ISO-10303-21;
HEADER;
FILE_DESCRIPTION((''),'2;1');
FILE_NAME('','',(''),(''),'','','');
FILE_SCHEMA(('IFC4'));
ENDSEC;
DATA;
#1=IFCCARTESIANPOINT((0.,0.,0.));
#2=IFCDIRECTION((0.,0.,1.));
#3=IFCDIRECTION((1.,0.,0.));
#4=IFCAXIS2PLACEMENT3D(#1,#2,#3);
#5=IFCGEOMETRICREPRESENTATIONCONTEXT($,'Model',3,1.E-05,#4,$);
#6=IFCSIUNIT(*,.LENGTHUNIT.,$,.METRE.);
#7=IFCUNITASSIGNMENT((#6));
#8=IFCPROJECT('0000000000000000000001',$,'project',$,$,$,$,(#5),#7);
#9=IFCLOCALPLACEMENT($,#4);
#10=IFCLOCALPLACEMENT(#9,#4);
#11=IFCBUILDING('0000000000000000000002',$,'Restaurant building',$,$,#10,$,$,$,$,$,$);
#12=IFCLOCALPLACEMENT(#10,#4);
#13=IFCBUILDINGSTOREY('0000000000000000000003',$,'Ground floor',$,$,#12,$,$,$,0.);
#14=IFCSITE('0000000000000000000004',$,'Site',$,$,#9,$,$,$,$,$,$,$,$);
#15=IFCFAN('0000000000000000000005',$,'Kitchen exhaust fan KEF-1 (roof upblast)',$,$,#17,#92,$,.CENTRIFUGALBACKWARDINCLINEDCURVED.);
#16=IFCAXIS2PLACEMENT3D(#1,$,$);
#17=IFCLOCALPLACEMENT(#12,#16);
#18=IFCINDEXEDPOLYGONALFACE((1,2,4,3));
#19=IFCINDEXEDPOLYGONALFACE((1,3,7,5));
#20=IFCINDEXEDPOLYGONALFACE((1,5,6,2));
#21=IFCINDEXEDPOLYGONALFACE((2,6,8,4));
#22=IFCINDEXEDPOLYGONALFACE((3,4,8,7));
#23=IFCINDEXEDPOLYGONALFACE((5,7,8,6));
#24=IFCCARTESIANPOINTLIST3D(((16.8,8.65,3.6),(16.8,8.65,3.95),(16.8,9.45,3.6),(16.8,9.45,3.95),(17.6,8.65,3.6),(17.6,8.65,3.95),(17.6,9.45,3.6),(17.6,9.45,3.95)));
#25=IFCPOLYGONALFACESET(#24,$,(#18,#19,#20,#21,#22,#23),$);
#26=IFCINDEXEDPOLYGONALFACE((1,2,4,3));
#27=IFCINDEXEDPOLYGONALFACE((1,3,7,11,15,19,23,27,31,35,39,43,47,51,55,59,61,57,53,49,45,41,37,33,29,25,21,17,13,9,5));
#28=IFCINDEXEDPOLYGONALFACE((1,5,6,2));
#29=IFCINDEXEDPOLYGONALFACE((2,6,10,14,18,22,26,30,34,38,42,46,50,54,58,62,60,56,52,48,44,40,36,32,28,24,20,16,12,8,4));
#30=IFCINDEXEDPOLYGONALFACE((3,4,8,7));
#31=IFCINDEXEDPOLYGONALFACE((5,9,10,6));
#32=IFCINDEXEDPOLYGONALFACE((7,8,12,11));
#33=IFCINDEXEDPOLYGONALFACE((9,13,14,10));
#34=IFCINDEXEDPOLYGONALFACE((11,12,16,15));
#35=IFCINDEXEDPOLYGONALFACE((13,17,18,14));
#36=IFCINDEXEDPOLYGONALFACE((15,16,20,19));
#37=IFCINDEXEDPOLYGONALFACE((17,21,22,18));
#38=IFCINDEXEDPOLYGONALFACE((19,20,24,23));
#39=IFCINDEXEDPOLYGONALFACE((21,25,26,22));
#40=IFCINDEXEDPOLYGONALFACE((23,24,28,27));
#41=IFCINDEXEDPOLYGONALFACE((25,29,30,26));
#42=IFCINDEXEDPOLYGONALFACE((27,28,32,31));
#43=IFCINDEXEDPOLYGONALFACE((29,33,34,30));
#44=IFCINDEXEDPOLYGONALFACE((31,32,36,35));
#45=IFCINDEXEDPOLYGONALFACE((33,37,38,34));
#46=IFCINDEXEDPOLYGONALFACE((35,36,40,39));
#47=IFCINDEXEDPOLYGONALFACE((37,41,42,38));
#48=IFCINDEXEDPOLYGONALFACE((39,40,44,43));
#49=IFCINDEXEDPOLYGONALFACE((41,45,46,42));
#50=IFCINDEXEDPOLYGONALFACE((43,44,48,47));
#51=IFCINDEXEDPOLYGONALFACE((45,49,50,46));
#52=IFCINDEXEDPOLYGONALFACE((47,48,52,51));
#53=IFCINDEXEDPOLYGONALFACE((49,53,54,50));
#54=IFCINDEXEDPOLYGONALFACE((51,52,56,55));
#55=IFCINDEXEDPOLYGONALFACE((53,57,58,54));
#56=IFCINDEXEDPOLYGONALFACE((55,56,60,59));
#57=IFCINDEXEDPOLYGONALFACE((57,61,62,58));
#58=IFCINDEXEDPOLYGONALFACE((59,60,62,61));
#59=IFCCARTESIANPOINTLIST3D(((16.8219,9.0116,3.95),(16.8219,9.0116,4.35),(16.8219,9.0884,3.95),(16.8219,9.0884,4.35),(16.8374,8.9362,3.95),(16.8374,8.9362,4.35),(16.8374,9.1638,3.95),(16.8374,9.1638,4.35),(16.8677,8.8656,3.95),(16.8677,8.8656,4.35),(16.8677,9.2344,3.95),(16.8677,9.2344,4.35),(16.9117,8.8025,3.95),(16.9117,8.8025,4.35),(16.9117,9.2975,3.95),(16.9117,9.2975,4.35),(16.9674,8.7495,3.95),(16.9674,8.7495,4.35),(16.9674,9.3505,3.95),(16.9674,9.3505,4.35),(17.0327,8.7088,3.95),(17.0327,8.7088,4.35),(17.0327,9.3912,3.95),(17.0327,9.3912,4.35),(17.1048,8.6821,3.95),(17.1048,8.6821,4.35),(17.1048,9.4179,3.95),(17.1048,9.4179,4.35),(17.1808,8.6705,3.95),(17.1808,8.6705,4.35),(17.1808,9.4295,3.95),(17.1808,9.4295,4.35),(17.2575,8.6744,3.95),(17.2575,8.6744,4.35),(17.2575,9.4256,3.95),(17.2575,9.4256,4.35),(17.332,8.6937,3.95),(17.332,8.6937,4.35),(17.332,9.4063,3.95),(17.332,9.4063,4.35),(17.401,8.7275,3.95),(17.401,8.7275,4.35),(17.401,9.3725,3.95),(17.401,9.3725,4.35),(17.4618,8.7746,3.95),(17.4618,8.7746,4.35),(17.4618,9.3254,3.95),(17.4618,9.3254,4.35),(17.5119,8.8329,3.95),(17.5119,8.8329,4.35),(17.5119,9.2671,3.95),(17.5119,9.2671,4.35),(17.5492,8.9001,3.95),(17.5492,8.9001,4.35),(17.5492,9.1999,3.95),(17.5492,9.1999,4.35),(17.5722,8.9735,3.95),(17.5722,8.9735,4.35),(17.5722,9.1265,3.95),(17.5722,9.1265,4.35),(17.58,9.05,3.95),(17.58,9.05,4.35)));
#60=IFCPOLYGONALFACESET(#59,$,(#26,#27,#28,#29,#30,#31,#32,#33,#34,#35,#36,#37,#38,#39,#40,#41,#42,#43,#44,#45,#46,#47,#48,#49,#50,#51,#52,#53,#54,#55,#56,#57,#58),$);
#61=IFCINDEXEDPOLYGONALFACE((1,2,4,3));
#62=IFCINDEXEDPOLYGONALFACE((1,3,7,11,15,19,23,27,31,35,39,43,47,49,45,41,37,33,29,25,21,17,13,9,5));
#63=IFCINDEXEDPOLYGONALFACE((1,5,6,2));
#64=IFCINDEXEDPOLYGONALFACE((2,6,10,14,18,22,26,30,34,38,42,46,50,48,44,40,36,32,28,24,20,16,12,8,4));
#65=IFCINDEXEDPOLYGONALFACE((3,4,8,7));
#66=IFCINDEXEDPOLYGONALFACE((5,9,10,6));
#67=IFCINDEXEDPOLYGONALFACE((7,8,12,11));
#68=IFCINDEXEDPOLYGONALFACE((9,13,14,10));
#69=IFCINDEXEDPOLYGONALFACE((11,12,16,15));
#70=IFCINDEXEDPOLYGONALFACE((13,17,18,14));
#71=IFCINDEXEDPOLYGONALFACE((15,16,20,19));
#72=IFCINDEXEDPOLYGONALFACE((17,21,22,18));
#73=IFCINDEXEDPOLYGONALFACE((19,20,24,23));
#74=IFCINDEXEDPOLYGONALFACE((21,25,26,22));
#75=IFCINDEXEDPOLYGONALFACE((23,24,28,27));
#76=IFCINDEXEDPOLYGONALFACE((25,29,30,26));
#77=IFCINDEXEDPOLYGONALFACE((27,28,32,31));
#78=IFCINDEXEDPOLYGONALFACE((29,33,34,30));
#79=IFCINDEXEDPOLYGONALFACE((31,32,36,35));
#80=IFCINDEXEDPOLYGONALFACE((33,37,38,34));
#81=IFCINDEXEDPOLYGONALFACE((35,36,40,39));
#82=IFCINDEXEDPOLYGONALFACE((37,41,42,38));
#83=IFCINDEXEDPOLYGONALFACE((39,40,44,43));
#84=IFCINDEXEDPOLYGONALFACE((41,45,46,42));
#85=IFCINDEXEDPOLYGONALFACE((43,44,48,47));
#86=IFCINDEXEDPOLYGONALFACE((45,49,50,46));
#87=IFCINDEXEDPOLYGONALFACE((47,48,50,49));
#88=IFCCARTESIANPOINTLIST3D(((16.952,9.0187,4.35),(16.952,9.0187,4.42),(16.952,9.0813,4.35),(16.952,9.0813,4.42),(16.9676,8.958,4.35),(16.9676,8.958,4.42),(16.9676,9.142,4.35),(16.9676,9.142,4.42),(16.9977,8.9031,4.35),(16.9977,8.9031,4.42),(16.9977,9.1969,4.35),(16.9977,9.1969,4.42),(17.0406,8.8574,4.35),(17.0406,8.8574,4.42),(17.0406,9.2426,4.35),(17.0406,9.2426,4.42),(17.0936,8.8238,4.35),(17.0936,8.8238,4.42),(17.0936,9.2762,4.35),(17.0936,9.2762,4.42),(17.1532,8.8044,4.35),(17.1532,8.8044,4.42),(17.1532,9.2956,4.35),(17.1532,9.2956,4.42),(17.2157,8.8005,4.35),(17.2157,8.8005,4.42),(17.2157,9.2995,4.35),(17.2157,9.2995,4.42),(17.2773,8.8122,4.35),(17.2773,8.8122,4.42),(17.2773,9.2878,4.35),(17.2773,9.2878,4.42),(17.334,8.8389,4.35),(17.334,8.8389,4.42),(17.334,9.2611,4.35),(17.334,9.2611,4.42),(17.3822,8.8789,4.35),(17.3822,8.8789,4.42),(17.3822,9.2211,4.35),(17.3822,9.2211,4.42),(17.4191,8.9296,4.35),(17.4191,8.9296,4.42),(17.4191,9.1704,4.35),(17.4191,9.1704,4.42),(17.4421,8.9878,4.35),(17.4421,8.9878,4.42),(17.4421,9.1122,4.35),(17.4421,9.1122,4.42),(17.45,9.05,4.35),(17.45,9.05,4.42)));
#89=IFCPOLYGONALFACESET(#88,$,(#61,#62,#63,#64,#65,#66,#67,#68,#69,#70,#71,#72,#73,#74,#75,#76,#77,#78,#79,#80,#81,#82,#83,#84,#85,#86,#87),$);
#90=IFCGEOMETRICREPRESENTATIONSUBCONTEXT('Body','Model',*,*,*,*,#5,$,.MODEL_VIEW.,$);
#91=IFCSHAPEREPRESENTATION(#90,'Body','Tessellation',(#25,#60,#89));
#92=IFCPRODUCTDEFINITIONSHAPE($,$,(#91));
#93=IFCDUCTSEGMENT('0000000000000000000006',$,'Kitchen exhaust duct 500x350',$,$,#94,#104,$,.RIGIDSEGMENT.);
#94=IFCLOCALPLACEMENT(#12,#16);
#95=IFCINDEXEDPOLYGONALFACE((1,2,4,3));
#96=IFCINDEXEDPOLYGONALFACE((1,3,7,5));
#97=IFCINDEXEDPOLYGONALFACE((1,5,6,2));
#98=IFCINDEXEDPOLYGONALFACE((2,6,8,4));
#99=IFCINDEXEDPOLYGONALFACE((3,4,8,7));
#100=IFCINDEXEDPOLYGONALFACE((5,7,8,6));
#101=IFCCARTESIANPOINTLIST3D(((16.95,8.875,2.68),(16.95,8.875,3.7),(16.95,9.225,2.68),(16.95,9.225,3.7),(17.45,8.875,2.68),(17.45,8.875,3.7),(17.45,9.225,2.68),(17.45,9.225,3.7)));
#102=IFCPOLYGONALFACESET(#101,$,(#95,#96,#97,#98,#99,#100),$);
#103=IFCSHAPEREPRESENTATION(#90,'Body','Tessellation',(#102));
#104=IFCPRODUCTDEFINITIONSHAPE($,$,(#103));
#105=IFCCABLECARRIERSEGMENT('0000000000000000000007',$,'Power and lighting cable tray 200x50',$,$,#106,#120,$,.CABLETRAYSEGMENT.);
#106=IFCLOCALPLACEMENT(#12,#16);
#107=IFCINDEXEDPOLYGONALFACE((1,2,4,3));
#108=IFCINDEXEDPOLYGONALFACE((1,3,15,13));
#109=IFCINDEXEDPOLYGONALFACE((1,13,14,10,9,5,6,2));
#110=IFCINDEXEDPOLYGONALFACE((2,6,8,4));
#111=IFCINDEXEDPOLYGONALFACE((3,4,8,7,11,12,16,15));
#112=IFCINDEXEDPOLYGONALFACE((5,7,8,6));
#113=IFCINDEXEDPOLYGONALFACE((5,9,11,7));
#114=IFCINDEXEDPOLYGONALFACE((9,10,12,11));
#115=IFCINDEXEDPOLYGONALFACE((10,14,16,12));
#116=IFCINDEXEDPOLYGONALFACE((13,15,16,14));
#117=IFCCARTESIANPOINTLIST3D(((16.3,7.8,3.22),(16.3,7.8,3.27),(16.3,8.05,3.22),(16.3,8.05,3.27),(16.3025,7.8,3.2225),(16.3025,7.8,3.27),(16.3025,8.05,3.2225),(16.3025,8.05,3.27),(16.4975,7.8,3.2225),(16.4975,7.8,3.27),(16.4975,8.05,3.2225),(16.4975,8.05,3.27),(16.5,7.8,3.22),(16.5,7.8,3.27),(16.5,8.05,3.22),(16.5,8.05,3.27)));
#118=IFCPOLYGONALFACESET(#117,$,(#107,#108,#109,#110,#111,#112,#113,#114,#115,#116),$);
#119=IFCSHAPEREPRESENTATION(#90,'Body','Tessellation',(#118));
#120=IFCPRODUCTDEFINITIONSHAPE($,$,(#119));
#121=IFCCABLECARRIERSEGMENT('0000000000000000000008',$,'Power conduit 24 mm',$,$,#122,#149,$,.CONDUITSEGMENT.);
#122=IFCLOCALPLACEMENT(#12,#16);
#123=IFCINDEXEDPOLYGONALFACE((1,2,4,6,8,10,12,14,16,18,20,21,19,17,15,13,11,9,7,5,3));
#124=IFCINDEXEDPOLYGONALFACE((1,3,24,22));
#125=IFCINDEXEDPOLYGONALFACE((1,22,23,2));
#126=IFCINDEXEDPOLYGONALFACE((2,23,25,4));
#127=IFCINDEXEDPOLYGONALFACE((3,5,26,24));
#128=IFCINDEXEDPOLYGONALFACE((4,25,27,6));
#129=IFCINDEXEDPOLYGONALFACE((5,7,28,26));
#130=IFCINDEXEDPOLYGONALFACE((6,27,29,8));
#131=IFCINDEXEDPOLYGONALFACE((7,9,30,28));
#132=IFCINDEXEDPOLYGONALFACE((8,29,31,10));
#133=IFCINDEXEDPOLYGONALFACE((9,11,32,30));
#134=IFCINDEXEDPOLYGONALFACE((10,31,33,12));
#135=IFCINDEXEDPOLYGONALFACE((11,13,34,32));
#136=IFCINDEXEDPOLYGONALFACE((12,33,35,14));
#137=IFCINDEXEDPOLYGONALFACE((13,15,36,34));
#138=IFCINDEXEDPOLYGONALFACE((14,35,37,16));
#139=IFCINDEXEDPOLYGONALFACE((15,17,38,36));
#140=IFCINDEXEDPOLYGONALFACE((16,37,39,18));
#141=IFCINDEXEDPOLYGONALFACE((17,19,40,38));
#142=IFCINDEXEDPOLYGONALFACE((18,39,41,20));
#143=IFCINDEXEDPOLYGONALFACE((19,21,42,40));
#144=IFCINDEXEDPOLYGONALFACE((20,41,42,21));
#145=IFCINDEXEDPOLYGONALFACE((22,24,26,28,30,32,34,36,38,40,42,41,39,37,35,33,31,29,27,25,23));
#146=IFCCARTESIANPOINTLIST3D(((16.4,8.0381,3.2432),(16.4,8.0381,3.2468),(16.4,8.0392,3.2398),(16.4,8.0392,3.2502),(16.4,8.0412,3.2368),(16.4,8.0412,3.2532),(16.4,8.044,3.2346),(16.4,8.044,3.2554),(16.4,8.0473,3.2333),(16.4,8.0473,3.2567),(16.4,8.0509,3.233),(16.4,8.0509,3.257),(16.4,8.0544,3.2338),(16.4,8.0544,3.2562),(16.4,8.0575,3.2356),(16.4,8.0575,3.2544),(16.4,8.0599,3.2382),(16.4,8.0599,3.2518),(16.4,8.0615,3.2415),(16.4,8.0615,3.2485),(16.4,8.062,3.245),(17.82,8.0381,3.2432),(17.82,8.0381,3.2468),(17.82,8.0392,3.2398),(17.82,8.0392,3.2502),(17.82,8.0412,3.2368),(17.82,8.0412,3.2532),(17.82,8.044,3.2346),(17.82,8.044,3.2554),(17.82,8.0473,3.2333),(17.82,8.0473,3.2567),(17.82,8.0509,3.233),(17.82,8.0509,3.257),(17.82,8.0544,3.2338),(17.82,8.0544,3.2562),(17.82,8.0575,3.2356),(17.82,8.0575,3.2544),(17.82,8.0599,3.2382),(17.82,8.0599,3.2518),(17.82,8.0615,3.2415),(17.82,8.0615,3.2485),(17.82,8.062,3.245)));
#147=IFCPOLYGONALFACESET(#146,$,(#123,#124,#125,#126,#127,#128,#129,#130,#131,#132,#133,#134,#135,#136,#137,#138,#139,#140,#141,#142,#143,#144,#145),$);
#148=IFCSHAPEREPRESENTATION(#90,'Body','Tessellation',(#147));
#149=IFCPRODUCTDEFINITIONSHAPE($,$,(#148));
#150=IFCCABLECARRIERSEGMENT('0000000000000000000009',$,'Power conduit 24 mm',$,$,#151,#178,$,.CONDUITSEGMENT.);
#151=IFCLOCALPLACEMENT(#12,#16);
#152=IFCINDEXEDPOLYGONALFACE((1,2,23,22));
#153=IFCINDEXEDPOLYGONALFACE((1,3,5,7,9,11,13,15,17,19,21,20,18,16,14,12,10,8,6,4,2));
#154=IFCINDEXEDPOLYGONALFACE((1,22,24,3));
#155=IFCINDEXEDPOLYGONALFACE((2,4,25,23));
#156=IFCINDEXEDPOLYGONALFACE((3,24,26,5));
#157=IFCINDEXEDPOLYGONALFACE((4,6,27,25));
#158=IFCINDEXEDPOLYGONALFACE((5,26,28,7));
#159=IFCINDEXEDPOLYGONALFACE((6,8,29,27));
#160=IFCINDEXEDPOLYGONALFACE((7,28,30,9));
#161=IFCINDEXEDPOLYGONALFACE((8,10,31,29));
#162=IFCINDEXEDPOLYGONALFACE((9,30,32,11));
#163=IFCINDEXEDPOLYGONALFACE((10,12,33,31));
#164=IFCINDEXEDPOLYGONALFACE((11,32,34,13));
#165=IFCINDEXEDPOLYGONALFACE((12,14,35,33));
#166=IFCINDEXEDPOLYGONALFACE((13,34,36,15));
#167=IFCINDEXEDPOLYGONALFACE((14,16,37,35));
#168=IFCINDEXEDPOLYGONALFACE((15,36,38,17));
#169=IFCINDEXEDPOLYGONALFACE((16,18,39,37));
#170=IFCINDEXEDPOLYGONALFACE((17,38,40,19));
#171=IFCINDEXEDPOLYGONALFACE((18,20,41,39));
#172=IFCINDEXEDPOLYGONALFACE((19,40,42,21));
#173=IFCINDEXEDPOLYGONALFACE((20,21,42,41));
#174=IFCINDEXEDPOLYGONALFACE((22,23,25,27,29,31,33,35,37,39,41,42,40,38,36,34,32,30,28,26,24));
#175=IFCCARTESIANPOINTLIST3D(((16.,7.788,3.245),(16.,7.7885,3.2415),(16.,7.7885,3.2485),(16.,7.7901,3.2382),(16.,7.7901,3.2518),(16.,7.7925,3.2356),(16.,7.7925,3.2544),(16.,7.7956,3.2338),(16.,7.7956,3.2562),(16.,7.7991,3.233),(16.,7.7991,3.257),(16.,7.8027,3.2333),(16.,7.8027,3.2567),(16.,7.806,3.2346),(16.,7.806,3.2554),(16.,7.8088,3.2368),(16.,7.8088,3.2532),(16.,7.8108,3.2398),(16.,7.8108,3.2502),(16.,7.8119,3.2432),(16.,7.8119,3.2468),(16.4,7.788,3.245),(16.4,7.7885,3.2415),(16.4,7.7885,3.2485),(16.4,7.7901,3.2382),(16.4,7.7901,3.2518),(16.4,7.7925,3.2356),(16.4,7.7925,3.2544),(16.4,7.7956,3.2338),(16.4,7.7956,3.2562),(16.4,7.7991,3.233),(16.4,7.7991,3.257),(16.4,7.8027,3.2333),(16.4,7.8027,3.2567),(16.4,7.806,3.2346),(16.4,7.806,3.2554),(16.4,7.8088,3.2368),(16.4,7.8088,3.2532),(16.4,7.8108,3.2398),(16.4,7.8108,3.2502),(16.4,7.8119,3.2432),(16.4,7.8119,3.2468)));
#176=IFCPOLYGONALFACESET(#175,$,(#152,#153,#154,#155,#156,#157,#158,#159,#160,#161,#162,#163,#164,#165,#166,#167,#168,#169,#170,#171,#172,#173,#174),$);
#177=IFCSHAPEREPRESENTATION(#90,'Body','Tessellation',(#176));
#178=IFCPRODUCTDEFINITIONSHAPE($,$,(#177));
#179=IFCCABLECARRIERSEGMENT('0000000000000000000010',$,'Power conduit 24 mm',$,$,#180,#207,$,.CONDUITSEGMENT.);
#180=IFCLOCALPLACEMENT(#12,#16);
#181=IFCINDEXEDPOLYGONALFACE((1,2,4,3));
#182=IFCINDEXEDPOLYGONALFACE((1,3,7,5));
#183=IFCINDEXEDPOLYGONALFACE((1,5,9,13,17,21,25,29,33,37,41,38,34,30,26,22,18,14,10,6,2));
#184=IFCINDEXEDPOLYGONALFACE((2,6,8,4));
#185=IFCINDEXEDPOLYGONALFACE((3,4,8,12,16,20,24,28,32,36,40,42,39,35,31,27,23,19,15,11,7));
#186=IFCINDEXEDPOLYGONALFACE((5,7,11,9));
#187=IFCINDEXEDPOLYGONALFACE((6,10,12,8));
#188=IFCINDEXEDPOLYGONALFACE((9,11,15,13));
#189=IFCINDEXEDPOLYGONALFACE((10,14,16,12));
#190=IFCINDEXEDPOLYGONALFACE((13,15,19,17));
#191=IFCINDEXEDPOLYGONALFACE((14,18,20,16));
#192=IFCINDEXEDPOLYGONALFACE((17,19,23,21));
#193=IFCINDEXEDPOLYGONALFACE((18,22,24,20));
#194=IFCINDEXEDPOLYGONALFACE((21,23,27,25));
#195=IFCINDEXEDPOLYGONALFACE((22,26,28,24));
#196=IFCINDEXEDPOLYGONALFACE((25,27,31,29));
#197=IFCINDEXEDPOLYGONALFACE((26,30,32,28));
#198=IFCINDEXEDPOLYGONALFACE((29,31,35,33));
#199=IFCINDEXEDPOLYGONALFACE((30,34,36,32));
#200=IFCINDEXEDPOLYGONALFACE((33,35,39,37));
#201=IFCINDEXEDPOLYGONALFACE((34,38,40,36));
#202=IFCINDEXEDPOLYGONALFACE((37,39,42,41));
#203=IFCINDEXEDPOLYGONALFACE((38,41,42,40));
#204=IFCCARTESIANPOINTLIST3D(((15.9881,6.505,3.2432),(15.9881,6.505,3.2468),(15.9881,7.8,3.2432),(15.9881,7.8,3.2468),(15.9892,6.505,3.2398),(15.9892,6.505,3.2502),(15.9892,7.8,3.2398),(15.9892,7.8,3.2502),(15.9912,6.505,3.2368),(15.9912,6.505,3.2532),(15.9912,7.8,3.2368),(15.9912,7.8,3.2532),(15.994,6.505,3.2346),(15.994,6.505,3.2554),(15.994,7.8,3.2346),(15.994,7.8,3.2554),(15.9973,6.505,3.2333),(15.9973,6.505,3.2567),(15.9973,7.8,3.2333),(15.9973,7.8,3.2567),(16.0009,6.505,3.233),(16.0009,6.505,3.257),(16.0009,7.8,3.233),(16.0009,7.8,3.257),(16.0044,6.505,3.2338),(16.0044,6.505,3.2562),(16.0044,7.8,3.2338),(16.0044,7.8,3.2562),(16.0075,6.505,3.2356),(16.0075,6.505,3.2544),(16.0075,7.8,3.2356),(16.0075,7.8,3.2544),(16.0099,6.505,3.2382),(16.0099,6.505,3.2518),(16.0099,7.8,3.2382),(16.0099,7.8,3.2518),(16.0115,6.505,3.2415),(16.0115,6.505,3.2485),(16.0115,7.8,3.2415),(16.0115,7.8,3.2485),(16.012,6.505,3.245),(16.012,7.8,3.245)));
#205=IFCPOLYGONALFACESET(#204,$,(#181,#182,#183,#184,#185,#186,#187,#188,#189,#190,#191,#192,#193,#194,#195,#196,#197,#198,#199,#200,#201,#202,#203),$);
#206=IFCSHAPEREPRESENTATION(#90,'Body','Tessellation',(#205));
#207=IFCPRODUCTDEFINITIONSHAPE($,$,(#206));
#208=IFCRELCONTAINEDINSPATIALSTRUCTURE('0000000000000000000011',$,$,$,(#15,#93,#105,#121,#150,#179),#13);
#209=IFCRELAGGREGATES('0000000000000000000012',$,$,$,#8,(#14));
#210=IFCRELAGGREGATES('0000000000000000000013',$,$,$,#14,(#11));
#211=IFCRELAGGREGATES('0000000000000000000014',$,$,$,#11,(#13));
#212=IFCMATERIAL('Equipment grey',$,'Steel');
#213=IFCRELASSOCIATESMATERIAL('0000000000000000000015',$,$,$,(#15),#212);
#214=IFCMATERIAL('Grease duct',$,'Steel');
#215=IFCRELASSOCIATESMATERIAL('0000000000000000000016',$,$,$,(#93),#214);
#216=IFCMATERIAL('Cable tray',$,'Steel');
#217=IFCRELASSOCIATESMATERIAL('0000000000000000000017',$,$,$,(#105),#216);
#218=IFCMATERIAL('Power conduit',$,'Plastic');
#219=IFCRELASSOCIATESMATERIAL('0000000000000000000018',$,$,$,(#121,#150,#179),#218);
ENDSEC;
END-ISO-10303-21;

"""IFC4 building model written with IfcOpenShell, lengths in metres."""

from ifc_helpers import new_model, si_unit, frame, origin, origin_with_axes, origin_2d, place, context, subcontext, project, spatial, polyline, rectangle, circle, outline, extrude, material, element, save


model = new_model("IFC4")

# Units and contexts
model_context = context("Model", 3, precision=1e-05, world=origin_with_axes())
body_context = subcontext(model_context, "Body", "Model", "MODEL_VIEW")
ifc_project = project(units=[si_unit("LENGTHUNIT", "METRE")], contexts=[model_context])

# Site, building, storey
site_placement = place(None, origin_with_axes())
site = spatial("IfcSite", under=ifc_project, at=site_placement, Name="Site")
building_placement = place(site_placement, origin_with_axes())
building = spatial("IfcBuilding", under=site, at=building_placement, Name="Restaurant building")
storey_placement = place(building_placement, origin_with_axes())
storey = spatial("IfcBuildingStorey", under=building, at=storey_placement, Name="Ground floor", Elevation=0.0)

# Fan
ifc_material_1 = material(Name="Equipment grey", Category="Steel")
fan_placement = place(storey_placement, frame((17.2, 9.05, 0.0)))
element("IfcFan", 1, at=fan_placement, inside=storey, material=ifc_material_1, Name="Kitchen exhaust fan KEF-1 (roof upblast)", PredefinedType="CENTRIFUGALBACKWARDINCLINEDCURVED", context=body_context, shape_type="SweptSolid", body=[
    extrude(rectangle(XDim=0.8, YDim=0.8, at=origin_2d()), frame((0.0, 0.0, 3.6)), (0.0, 0.0, 1.0), 0.35),
    extrude(circle(Radius=0.38, at=origin_2d()), frame((0.0, 0.0, 3.95)), (0.0, 0.0, 1.0), 0.4),
    extrude(circle(Radius=0.25, at=origin_2d()), frame((0.0, 0.0, 4.35)), (0.0, 0.0, 1.0), 0.07),
])

# Duct segment
ifc_material_2 = material(Name="Grease duct", Category="Steel")
duct_segment_placement = place(storey_placement, frame((17.2, 9.05, 2.68)))
element("IfcDuctSegment", 2, at=duct_segment_placement, inside=storey, material=ifc_material_2, Name="Kitchen exhaust duct 500x350", PredefinedType="RIGIDSEGMENT", context=body_context, shape_type="SweptSolid", body=[
    extrude(rectangle(XDim=0.5, YDim=0.35, at=origin_2d()), origin(), (0.0, 0.0, 1.0), 1.02),
])

# Cable carrier segments
ifc_material_3 = material(Name="Cable tray", Category="Steel")
cable_carrier_segment_1_placement = place(storey_placement, frame((16.4, 8.05, 3.245)))
element("IfcCableCarrierSegment", 3, at=cable_carrier_segment_1_placement, inside=storey, material=ifc_material_3, Name="Power and lighting cable tray 200x50", PredefinedType="CABLETRAYSEGMENT", context=body_context, shape_type="SweptSolid", body=[
    extrude(outline(polyline([(-0.1, -0.025), (0.1, -0.025), (0.1, 0.025), (0.0975, 0.025), (0.0975, -0.0225), (-0.0975, -0.0225), (-0.0975, 0.025), (-0.1, 0.025), (-0.1, -0.025)])), frame((0.0, 0.0, 0.0), z_axis=(0.0, -1.0, 0.0), x_axis=(1.0, 0.0, 0.0)), (0.0, 0.0, 1.0), 0.25),
])
ifc_material_4 = material(Name="Power conduit", Category="Plastic")
cable_carrier_segment_2_placement = place(storey_placement, frame((16.4, 8.05, 3.245)))
element("IfcCableCarrierSegment", 4, at=cable_carrier_segment_2_placement, inside=storey, material=ifc_material_4, Name="Power conduit 24 mm", PredefinedType="CONDUITSEGMENT", context=body_context, shape_type="SweptSolid", body=[
    extrude(circle(Radius=0.012, at=origin_2d()), frame((0.0, 0.0, 0.0), z_axis=(1.0, 0.0, 0.0), x_axis=(0.0, 1.0, 0.0)), (0.0, 0.0, 1.0), 1.42),
])
cable_carrier_segment_3_placement = place(storey_placement, frame((16.4, 7.8, 3.245)))
element("IfcCableCarrierSegment", 5, at=cable_carrier_segment_3_placement, inside=storey, material=ifc_material_4, Name="Power conduit 24 mm", PredefinedType="CONDUITSEGMENT", context=body_context, shape_type="SweptSolid", body=[
    extrude(circle(Radius=0.012, at=origin_2d()), frame((0.0, 0.0, 0.0), z_axis=(-1.0, 0.0, 0.0), x_axis=(0.0, -1.0, 0.0)), (0.0, 0.0, 1.0), 0.4),
])
cable_carrier_segment_4_placement = place(storey_placement, frame((16.0, 7.8, 3.245)))
element("IfcCableCarrierSegment", 6, at=cable_carrier_segment_4_placement, inside=storey, material=ifc_material_4, Name="Power conduit 24 mm", PredefinedType="CONDUITSEGMENT", context=body_context, shape_type="SweptSolid", body=[
    extrude(circle(Radius=0.012, at=origin_2d()), frame((0.0, 0.0, 0.0), z_axis=(0.0, -1.0, 0.0), x_axis=(1.0, 0.0, 0.0)), (0.0, 0.0, 1.0), 1.295),
])

save(model, "model.ifc")
